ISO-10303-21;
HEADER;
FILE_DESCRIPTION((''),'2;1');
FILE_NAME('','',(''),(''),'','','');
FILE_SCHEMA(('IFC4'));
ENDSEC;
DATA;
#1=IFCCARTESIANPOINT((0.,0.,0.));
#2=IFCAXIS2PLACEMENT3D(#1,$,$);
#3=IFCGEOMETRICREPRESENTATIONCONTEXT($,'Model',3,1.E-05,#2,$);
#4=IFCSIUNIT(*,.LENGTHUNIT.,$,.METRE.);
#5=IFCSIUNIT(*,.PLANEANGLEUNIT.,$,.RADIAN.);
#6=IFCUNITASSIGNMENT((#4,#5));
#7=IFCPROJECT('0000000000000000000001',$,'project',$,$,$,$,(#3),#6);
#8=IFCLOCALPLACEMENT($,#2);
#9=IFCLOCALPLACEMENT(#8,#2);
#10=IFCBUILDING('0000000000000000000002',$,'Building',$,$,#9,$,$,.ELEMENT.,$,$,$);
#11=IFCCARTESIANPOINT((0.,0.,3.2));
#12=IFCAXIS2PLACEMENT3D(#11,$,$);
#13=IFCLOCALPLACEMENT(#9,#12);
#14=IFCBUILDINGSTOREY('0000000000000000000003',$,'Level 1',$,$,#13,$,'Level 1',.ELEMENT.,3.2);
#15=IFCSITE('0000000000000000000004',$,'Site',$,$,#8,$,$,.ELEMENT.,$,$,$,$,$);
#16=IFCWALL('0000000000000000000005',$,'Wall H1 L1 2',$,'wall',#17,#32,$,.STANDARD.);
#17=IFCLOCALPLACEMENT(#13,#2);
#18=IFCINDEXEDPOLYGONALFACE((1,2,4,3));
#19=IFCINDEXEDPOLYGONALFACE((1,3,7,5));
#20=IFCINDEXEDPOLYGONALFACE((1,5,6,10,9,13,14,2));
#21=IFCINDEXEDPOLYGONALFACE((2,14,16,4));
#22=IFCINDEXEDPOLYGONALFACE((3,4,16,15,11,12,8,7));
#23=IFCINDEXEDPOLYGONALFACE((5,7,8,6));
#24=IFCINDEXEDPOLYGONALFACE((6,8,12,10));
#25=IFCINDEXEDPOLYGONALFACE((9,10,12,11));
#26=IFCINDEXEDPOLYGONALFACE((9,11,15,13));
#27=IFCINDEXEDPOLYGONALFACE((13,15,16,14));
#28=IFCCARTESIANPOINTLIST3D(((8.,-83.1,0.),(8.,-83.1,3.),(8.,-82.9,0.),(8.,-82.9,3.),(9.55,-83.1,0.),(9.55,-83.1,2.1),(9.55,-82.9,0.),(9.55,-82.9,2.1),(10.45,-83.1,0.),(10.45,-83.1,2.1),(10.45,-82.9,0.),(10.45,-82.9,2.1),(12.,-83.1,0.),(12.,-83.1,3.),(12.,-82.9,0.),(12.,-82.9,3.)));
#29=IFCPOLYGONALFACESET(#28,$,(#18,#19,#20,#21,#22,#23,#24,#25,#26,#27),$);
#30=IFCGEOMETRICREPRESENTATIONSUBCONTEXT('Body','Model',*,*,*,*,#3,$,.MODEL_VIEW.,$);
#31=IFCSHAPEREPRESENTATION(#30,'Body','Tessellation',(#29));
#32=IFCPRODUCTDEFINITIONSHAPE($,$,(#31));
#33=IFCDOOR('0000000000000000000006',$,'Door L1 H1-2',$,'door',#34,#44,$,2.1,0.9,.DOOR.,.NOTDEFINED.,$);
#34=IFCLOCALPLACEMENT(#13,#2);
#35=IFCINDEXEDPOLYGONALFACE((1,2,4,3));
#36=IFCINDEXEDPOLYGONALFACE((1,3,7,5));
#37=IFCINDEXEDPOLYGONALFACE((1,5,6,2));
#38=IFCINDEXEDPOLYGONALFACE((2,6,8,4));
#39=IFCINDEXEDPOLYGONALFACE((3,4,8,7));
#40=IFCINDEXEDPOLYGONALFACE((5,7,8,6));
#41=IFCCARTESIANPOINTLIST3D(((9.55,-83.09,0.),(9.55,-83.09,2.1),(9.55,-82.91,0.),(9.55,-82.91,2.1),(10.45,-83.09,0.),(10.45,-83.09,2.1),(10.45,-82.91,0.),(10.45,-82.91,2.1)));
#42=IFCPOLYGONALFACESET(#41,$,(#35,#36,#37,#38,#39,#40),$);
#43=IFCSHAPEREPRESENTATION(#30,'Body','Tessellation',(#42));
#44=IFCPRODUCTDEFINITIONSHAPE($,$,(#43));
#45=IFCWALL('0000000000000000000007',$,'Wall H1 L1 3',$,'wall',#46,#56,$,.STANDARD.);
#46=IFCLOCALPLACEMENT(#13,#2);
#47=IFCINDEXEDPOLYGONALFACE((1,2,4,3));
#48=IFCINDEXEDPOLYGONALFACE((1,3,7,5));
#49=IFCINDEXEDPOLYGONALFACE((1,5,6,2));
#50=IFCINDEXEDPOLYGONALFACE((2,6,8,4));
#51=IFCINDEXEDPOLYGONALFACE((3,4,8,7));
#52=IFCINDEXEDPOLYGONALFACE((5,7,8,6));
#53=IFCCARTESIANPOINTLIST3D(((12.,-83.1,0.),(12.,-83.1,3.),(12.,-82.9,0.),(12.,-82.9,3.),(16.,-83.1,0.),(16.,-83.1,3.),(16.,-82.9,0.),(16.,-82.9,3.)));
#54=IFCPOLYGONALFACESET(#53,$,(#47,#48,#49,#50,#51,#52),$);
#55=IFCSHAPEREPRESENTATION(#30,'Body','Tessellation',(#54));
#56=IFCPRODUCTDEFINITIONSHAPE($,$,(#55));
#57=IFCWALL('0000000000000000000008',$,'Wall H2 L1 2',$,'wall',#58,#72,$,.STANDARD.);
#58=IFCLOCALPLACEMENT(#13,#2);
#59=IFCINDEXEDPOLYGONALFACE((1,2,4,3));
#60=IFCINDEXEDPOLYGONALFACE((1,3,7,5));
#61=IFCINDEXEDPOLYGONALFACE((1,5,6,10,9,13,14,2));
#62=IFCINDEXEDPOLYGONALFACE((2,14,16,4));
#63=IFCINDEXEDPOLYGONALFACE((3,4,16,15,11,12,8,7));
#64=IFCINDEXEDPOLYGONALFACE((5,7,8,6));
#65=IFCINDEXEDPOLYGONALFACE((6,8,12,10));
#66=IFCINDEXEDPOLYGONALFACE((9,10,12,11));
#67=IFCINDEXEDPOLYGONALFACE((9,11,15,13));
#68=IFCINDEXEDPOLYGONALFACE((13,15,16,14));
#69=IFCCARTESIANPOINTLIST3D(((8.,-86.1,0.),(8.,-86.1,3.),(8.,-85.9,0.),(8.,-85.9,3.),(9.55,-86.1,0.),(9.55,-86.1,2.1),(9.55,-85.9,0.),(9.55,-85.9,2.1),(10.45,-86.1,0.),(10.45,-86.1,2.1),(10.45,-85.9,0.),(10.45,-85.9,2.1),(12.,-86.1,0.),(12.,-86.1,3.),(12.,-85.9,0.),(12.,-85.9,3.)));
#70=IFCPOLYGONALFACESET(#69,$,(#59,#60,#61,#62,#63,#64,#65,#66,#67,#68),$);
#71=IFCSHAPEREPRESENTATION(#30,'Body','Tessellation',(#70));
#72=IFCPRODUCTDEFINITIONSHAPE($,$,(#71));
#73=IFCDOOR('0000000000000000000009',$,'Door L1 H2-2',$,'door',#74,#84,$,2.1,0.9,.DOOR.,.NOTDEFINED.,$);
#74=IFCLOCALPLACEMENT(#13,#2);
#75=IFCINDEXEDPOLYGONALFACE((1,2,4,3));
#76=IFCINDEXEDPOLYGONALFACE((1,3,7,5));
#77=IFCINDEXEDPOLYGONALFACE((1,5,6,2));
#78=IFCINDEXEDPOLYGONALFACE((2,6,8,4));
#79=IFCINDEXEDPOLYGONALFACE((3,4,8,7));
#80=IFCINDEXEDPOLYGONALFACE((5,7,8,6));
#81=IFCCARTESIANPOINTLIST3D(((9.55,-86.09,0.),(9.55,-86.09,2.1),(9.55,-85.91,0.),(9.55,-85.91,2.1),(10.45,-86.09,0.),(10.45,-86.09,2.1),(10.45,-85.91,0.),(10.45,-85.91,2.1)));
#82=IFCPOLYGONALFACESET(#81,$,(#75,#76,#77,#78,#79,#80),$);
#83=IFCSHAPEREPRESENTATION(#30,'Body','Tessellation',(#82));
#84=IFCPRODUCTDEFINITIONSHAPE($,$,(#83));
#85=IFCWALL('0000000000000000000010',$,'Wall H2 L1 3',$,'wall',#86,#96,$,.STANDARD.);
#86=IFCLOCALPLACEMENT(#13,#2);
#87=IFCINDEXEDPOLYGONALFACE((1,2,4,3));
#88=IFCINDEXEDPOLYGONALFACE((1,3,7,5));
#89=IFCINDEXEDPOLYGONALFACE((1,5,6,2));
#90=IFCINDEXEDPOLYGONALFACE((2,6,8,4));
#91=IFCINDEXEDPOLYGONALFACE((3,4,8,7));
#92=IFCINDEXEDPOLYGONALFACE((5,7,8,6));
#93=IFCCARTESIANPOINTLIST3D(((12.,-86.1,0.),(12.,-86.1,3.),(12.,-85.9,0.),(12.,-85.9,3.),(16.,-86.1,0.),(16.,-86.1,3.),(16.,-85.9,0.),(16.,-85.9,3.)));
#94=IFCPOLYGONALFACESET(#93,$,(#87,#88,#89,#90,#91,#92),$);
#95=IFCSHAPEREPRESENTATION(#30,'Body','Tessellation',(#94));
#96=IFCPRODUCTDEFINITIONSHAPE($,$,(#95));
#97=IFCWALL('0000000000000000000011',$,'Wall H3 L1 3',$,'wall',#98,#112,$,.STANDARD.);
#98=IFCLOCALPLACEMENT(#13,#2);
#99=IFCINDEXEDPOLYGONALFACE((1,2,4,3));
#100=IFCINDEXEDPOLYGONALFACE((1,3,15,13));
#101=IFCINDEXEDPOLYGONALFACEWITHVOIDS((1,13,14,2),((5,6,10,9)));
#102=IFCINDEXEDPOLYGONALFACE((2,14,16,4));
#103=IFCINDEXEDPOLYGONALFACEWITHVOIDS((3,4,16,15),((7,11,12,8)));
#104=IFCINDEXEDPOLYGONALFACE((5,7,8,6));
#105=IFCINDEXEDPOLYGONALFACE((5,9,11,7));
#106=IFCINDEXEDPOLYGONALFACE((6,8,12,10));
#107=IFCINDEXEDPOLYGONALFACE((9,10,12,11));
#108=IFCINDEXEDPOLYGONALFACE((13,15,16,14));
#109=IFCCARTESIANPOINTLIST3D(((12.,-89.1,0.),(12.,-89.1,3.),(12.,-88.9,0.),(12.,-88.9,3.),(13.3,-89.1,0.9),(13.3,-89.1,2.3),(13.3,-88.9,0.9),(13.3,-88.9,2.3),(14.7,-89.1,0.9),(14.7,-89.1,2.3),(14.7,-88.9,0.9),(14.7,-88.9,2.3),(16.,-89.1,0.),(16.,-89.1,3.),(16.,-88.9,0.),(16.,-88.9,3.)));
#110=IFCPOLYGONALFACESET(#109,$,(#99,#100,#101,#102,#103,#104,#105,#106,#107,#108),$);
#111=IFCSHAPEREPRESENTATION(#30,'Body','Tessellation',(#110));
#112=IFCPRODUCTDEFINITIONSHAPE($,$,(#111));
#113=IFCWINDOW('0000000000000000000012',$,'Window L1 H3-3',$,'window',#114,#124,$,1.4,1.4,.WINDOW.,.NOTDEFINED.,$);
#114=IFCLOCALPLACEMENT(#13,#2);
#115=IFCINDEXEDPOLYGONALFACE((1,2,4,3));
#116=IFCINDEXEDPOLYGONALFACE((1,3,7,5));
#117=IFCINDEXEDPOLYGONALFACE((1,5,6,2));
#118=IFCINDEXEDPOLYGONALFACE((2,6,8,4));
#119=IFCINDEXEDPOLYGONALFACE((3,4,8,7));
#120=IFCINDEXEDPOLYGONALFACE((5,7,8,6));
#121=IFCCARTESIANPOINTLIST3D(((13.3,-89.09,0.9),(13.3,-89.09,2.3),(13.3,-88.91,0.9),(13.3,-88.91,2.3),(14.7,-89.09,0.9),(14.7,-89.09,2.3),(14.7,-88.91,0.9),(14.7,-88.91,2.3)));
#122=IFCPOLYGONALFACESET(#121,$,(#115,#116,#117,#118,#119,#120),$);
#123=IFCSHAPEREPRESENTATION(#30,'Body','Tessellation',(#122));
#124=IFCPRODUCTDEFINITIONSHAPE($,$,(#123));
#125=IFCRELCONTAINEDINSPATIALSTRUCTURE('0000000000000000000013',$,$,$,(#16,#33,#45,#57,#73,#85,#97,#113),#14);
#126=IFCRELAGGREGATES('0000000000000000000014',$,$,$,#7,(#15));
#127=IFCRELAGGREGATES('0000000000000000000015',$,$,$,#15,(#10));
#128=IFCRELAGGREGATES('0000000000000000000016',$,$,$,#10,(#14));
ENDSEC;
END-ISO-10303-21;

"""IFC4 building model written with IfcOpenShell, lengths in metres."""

from ifc_helpers import new_model, si_unit, frame, frame_2d, origin, origin_2d, place, context, subcontext, project, spatial, rectangle, extrude, element, fill, save


model = new_model("IFC4")

# Units and contexts
model_context = context("Model", 3, precision=1e-05, world=origin())
body_context = subcontext(model_context, "Body", "Model", "MODEL_VIEW")
ifc_project = project(units=[si_unit("LENGTHUNIT", "METRE"), si_unit("PLANEANGLEUNIT", "RADIAN")], contexts=[model_context])

# Site, building, storey
site_placement = place(None, origin())
site = spatial("IfcSite", under=ifc_project, at=site_placement, Name="Site", CompositionType="ELEMENT")
building_placement = place(site_placement, origin())
building = spatial("IfcBuilding", under=site, at=building_placement, Name="Building", CompositionType="ELEMENT")
storey_placement = place(building_placement, frame((0.0, 0.0, 3.2)))
storey = spatial("IfcBuildingStorey", under=building, at=storey_placement, Name="Level 1", LongName="Level 1", CompositionType="ELEMENT", Elevation=3.2)

# Wall, opening, door
wall_1_placement = place(storey_placement, frame((8.0, -83.0, 0.0), z_axis=(0.0, 0.0, 1.0), x_axis=(1.0, 0.0, 0.0)))
wall_1 = element("IfcWall", 1, at=wall_1_placement, inside=storey, Name="Wall H1 L1 2", ObjectType="wall", PredefinedType="STANDARD", context=body_context, shape_type="SweptSolid", body=[
    extrude(rectangle(XDim=4.0, YDim=0.2, at=frame_2d((2.0, 0.0))), origin(), (0.0, 0.0, 1.0), 3.0),
])
opening_1_placement = place(storey_placement, frame((10.0, -83.0, 0.0), z_axis=(0.0, 0.0, 1.0), x_axis=(1.0, 0.0, 0.0)))
opening_1 = element("IfcOpeningElement", 2, at=opening_1_placement, cuts=wall_1, ObjectType="Opening", PredefinedType="OPENING", context=body_context, shape_type="SweptSolid", body=[
    extrude(rectangle(XDim=0.9, YDim=0.22, at=origin_2d()), origin(), (0.0, 0.0, 1.0), 2.1),
])
door_1_placement = place(storey_placement, frame((10.0, -83.0, 0.0), z_axis=(0.0, 0.0, 1.0), x_axis=(1.0, 0.0, 0.0)))
door_1 = element("IfcDoor", 3, at=door_1_placement, inside=storey, Name="Door L1 H1-2", ObjectType="door", OperationType="NOTDEFINED", OverallHeight=2.1, OverallWidth=0.9, PredefinedType="DOOR", context=body_context, shape_type="SweptSolid", body=[
    extrude(rectangle(XDim=0.9, YDim=0.18, at=origin_2d()), origin(), (0.0, 0.0, 1.0), 2.1),
])
fill(opening_1, door_1)

# Wall
wall_2_placement = place(storey_placement, frame((12.0, -83.0, 0.0), z_axis=(0.0, 0.0, 1.0), x_axis=(1.0, 0.0, 0.0)))
element("IfcWall", 4, at=wall_2_placement, inside=storey, Name="Wall H1 L1 3", ObjectType="wall", PredefinedType="STANDARD", context=body_context, shape_type="SweptSolid", body=[
    extrude(rectangle(XDim=4.0, YDim=0.2, at=frame_2d((2.0, 0.0))), origin(), (0.0, 0.0, 1.0), 3.0),
])

# Wall, opening, door
wall_3_placement = place(storey_placement, frame((8.0, -86.0, 0.0), z_axis=(0.0, 0.0, 1.0), x_axis=(1.0, 0.0, 0.0)))
wall_3 = element("IfcWall", 5, at=wall_3_placement, inside=storey, Name="Wall H2 L1 2", ObjectType="wall", PredefinedType="STANDARD", context=body_context, shape_type="SweptSolid", body=[
    extrude(rectangle(XDim=4.0, YDim=0.2, at=frame_2d((2.0, 0.0))), origin(), (0.0, 0.0, 1.0), 3.0),
])
opening_2_placement = place(storey_placement, frame((10.0, -86.0, 0.0), z_axis=(0.0, 0.0, 1.0), x_axis=(1.0, 0.0, 0.0)))
opening_2 = element("IfcOpeningElement", 6, at=opening_2_placement, cuts=wall_3, ObjectType="Opening", PredefinedType="OPENING", context=body_context, shape_type="SweptSolid", body=[
    extrude(rectangle(XDim=0.9, YDim=0.22, at=origin_2d()), origin(), (0.0, 0.0, 1.0), 2.1),
])
door_2_placement = place(storey_placement, frame((10.0, -86.0, 0.0), z_axis=(0.0, 0.0, 1.0), x_axis=(1.0, 0.0, 0.0)))
door_2 = element("IfcDoor", 7, at=door_2_placement, inside=storey, Name="Door L1 H2-2", ObjectType="door", OperationType="NOTDEFINED", OverallHeight=2.1, OverallWidth=0.9, PredefinedType="DOOR", context=body_context, shape_type="SweptSolid", body=[
    extrude(rectangle(XDim=0.9, YDim=0.18, at=origin_2d()), origin(), (0.0, 0.0, 1.0), 2.1),
])
fill(opening_2, door_2)

# Wall
wall_4_placement = place(storey_placement, frame((12.0, -86.0, 0.0), z_axis=(0.0, 0.0, 1.0), x_axis=(1.0, 0.0, 0.0)))
element("IfcWall", 8, at=wall_4_placement, inside=storey, Name="Wall H2 L1 3", ObjectType="wall", PredefinedType="STANDARD", context=body_context, shape_type="SweptSolid", body=[
    extrude(rectangle(XDim=4.0, YDim=0.2, at=frame_2d((2.0, 0.0))), origin(), (0.0, 0.0, 1.0), 3.0),
])

# Wall, opening, window
wall_5_placement = place(storey_placement, frame((12.0, -89.0, 0.0), z_axis=(0.0, 0.0, 1.0), x_axis=(1.0, 0.0, 0.0)))
wall_5 = element("IfcWall", 9, at=wall_5_placement, inside=storey, Name="Wall H3 L1 3", ObjectType="wall", PredefinedType="STANDARD", context=body_context, shape_type="SweptSolid", body=[
    extrude(rectangle(XDim=4.0, YDim=0.2, at=frame_2d((2.0, 0.0))), origin(), (0.0, 0.0, 1.0), 3.0),
])
opening_3_placement = place(storey_placement, frame((14.0, -89.0, 0.9), z_axis=(0.0, 0.0, 1.0), x_axis=(1.0, 0.0, 0.0)))
opening_3 = element("IfcOpeningElement", 10, at=opening_3_placement, cuts=wall_5, ObjectType="Opening", PredefinedType="OPENING", context=body_context, shape_type="SweptSolid", body=[
    extrude(rectangle(XDim=1.4, YDim=0.22, at=origin_2d()), origin(), (0.0, 0.0, 1.0), 1.4),
])
window_1_placement = place(storey_placement, frame((14.0, -89.0, 0.9), z_axis=(0.0, 0.0, 1.0), x_axis=(1.0, 0.0, 0.0)))
window_1 = element("IfcWindow", 11, at=window_1_placement, inside=storey, Name="Window L1 H3-3", ObjectType="window", OverallHeight=1.4, OverallWidth=1.4, PartitioningType="NOTDEFINED", PredefinedType="WINDOW", context=body_context, shape_type="SweptSolid", body=[
    extrude(rectangle(XDim=1.4, YDim=0.18, at=origin_2d()), origin(), (0.0, 0.0, 1.0), 1.4),
])
fill(opening_3, window_1)

save(model, "model.ifc")
